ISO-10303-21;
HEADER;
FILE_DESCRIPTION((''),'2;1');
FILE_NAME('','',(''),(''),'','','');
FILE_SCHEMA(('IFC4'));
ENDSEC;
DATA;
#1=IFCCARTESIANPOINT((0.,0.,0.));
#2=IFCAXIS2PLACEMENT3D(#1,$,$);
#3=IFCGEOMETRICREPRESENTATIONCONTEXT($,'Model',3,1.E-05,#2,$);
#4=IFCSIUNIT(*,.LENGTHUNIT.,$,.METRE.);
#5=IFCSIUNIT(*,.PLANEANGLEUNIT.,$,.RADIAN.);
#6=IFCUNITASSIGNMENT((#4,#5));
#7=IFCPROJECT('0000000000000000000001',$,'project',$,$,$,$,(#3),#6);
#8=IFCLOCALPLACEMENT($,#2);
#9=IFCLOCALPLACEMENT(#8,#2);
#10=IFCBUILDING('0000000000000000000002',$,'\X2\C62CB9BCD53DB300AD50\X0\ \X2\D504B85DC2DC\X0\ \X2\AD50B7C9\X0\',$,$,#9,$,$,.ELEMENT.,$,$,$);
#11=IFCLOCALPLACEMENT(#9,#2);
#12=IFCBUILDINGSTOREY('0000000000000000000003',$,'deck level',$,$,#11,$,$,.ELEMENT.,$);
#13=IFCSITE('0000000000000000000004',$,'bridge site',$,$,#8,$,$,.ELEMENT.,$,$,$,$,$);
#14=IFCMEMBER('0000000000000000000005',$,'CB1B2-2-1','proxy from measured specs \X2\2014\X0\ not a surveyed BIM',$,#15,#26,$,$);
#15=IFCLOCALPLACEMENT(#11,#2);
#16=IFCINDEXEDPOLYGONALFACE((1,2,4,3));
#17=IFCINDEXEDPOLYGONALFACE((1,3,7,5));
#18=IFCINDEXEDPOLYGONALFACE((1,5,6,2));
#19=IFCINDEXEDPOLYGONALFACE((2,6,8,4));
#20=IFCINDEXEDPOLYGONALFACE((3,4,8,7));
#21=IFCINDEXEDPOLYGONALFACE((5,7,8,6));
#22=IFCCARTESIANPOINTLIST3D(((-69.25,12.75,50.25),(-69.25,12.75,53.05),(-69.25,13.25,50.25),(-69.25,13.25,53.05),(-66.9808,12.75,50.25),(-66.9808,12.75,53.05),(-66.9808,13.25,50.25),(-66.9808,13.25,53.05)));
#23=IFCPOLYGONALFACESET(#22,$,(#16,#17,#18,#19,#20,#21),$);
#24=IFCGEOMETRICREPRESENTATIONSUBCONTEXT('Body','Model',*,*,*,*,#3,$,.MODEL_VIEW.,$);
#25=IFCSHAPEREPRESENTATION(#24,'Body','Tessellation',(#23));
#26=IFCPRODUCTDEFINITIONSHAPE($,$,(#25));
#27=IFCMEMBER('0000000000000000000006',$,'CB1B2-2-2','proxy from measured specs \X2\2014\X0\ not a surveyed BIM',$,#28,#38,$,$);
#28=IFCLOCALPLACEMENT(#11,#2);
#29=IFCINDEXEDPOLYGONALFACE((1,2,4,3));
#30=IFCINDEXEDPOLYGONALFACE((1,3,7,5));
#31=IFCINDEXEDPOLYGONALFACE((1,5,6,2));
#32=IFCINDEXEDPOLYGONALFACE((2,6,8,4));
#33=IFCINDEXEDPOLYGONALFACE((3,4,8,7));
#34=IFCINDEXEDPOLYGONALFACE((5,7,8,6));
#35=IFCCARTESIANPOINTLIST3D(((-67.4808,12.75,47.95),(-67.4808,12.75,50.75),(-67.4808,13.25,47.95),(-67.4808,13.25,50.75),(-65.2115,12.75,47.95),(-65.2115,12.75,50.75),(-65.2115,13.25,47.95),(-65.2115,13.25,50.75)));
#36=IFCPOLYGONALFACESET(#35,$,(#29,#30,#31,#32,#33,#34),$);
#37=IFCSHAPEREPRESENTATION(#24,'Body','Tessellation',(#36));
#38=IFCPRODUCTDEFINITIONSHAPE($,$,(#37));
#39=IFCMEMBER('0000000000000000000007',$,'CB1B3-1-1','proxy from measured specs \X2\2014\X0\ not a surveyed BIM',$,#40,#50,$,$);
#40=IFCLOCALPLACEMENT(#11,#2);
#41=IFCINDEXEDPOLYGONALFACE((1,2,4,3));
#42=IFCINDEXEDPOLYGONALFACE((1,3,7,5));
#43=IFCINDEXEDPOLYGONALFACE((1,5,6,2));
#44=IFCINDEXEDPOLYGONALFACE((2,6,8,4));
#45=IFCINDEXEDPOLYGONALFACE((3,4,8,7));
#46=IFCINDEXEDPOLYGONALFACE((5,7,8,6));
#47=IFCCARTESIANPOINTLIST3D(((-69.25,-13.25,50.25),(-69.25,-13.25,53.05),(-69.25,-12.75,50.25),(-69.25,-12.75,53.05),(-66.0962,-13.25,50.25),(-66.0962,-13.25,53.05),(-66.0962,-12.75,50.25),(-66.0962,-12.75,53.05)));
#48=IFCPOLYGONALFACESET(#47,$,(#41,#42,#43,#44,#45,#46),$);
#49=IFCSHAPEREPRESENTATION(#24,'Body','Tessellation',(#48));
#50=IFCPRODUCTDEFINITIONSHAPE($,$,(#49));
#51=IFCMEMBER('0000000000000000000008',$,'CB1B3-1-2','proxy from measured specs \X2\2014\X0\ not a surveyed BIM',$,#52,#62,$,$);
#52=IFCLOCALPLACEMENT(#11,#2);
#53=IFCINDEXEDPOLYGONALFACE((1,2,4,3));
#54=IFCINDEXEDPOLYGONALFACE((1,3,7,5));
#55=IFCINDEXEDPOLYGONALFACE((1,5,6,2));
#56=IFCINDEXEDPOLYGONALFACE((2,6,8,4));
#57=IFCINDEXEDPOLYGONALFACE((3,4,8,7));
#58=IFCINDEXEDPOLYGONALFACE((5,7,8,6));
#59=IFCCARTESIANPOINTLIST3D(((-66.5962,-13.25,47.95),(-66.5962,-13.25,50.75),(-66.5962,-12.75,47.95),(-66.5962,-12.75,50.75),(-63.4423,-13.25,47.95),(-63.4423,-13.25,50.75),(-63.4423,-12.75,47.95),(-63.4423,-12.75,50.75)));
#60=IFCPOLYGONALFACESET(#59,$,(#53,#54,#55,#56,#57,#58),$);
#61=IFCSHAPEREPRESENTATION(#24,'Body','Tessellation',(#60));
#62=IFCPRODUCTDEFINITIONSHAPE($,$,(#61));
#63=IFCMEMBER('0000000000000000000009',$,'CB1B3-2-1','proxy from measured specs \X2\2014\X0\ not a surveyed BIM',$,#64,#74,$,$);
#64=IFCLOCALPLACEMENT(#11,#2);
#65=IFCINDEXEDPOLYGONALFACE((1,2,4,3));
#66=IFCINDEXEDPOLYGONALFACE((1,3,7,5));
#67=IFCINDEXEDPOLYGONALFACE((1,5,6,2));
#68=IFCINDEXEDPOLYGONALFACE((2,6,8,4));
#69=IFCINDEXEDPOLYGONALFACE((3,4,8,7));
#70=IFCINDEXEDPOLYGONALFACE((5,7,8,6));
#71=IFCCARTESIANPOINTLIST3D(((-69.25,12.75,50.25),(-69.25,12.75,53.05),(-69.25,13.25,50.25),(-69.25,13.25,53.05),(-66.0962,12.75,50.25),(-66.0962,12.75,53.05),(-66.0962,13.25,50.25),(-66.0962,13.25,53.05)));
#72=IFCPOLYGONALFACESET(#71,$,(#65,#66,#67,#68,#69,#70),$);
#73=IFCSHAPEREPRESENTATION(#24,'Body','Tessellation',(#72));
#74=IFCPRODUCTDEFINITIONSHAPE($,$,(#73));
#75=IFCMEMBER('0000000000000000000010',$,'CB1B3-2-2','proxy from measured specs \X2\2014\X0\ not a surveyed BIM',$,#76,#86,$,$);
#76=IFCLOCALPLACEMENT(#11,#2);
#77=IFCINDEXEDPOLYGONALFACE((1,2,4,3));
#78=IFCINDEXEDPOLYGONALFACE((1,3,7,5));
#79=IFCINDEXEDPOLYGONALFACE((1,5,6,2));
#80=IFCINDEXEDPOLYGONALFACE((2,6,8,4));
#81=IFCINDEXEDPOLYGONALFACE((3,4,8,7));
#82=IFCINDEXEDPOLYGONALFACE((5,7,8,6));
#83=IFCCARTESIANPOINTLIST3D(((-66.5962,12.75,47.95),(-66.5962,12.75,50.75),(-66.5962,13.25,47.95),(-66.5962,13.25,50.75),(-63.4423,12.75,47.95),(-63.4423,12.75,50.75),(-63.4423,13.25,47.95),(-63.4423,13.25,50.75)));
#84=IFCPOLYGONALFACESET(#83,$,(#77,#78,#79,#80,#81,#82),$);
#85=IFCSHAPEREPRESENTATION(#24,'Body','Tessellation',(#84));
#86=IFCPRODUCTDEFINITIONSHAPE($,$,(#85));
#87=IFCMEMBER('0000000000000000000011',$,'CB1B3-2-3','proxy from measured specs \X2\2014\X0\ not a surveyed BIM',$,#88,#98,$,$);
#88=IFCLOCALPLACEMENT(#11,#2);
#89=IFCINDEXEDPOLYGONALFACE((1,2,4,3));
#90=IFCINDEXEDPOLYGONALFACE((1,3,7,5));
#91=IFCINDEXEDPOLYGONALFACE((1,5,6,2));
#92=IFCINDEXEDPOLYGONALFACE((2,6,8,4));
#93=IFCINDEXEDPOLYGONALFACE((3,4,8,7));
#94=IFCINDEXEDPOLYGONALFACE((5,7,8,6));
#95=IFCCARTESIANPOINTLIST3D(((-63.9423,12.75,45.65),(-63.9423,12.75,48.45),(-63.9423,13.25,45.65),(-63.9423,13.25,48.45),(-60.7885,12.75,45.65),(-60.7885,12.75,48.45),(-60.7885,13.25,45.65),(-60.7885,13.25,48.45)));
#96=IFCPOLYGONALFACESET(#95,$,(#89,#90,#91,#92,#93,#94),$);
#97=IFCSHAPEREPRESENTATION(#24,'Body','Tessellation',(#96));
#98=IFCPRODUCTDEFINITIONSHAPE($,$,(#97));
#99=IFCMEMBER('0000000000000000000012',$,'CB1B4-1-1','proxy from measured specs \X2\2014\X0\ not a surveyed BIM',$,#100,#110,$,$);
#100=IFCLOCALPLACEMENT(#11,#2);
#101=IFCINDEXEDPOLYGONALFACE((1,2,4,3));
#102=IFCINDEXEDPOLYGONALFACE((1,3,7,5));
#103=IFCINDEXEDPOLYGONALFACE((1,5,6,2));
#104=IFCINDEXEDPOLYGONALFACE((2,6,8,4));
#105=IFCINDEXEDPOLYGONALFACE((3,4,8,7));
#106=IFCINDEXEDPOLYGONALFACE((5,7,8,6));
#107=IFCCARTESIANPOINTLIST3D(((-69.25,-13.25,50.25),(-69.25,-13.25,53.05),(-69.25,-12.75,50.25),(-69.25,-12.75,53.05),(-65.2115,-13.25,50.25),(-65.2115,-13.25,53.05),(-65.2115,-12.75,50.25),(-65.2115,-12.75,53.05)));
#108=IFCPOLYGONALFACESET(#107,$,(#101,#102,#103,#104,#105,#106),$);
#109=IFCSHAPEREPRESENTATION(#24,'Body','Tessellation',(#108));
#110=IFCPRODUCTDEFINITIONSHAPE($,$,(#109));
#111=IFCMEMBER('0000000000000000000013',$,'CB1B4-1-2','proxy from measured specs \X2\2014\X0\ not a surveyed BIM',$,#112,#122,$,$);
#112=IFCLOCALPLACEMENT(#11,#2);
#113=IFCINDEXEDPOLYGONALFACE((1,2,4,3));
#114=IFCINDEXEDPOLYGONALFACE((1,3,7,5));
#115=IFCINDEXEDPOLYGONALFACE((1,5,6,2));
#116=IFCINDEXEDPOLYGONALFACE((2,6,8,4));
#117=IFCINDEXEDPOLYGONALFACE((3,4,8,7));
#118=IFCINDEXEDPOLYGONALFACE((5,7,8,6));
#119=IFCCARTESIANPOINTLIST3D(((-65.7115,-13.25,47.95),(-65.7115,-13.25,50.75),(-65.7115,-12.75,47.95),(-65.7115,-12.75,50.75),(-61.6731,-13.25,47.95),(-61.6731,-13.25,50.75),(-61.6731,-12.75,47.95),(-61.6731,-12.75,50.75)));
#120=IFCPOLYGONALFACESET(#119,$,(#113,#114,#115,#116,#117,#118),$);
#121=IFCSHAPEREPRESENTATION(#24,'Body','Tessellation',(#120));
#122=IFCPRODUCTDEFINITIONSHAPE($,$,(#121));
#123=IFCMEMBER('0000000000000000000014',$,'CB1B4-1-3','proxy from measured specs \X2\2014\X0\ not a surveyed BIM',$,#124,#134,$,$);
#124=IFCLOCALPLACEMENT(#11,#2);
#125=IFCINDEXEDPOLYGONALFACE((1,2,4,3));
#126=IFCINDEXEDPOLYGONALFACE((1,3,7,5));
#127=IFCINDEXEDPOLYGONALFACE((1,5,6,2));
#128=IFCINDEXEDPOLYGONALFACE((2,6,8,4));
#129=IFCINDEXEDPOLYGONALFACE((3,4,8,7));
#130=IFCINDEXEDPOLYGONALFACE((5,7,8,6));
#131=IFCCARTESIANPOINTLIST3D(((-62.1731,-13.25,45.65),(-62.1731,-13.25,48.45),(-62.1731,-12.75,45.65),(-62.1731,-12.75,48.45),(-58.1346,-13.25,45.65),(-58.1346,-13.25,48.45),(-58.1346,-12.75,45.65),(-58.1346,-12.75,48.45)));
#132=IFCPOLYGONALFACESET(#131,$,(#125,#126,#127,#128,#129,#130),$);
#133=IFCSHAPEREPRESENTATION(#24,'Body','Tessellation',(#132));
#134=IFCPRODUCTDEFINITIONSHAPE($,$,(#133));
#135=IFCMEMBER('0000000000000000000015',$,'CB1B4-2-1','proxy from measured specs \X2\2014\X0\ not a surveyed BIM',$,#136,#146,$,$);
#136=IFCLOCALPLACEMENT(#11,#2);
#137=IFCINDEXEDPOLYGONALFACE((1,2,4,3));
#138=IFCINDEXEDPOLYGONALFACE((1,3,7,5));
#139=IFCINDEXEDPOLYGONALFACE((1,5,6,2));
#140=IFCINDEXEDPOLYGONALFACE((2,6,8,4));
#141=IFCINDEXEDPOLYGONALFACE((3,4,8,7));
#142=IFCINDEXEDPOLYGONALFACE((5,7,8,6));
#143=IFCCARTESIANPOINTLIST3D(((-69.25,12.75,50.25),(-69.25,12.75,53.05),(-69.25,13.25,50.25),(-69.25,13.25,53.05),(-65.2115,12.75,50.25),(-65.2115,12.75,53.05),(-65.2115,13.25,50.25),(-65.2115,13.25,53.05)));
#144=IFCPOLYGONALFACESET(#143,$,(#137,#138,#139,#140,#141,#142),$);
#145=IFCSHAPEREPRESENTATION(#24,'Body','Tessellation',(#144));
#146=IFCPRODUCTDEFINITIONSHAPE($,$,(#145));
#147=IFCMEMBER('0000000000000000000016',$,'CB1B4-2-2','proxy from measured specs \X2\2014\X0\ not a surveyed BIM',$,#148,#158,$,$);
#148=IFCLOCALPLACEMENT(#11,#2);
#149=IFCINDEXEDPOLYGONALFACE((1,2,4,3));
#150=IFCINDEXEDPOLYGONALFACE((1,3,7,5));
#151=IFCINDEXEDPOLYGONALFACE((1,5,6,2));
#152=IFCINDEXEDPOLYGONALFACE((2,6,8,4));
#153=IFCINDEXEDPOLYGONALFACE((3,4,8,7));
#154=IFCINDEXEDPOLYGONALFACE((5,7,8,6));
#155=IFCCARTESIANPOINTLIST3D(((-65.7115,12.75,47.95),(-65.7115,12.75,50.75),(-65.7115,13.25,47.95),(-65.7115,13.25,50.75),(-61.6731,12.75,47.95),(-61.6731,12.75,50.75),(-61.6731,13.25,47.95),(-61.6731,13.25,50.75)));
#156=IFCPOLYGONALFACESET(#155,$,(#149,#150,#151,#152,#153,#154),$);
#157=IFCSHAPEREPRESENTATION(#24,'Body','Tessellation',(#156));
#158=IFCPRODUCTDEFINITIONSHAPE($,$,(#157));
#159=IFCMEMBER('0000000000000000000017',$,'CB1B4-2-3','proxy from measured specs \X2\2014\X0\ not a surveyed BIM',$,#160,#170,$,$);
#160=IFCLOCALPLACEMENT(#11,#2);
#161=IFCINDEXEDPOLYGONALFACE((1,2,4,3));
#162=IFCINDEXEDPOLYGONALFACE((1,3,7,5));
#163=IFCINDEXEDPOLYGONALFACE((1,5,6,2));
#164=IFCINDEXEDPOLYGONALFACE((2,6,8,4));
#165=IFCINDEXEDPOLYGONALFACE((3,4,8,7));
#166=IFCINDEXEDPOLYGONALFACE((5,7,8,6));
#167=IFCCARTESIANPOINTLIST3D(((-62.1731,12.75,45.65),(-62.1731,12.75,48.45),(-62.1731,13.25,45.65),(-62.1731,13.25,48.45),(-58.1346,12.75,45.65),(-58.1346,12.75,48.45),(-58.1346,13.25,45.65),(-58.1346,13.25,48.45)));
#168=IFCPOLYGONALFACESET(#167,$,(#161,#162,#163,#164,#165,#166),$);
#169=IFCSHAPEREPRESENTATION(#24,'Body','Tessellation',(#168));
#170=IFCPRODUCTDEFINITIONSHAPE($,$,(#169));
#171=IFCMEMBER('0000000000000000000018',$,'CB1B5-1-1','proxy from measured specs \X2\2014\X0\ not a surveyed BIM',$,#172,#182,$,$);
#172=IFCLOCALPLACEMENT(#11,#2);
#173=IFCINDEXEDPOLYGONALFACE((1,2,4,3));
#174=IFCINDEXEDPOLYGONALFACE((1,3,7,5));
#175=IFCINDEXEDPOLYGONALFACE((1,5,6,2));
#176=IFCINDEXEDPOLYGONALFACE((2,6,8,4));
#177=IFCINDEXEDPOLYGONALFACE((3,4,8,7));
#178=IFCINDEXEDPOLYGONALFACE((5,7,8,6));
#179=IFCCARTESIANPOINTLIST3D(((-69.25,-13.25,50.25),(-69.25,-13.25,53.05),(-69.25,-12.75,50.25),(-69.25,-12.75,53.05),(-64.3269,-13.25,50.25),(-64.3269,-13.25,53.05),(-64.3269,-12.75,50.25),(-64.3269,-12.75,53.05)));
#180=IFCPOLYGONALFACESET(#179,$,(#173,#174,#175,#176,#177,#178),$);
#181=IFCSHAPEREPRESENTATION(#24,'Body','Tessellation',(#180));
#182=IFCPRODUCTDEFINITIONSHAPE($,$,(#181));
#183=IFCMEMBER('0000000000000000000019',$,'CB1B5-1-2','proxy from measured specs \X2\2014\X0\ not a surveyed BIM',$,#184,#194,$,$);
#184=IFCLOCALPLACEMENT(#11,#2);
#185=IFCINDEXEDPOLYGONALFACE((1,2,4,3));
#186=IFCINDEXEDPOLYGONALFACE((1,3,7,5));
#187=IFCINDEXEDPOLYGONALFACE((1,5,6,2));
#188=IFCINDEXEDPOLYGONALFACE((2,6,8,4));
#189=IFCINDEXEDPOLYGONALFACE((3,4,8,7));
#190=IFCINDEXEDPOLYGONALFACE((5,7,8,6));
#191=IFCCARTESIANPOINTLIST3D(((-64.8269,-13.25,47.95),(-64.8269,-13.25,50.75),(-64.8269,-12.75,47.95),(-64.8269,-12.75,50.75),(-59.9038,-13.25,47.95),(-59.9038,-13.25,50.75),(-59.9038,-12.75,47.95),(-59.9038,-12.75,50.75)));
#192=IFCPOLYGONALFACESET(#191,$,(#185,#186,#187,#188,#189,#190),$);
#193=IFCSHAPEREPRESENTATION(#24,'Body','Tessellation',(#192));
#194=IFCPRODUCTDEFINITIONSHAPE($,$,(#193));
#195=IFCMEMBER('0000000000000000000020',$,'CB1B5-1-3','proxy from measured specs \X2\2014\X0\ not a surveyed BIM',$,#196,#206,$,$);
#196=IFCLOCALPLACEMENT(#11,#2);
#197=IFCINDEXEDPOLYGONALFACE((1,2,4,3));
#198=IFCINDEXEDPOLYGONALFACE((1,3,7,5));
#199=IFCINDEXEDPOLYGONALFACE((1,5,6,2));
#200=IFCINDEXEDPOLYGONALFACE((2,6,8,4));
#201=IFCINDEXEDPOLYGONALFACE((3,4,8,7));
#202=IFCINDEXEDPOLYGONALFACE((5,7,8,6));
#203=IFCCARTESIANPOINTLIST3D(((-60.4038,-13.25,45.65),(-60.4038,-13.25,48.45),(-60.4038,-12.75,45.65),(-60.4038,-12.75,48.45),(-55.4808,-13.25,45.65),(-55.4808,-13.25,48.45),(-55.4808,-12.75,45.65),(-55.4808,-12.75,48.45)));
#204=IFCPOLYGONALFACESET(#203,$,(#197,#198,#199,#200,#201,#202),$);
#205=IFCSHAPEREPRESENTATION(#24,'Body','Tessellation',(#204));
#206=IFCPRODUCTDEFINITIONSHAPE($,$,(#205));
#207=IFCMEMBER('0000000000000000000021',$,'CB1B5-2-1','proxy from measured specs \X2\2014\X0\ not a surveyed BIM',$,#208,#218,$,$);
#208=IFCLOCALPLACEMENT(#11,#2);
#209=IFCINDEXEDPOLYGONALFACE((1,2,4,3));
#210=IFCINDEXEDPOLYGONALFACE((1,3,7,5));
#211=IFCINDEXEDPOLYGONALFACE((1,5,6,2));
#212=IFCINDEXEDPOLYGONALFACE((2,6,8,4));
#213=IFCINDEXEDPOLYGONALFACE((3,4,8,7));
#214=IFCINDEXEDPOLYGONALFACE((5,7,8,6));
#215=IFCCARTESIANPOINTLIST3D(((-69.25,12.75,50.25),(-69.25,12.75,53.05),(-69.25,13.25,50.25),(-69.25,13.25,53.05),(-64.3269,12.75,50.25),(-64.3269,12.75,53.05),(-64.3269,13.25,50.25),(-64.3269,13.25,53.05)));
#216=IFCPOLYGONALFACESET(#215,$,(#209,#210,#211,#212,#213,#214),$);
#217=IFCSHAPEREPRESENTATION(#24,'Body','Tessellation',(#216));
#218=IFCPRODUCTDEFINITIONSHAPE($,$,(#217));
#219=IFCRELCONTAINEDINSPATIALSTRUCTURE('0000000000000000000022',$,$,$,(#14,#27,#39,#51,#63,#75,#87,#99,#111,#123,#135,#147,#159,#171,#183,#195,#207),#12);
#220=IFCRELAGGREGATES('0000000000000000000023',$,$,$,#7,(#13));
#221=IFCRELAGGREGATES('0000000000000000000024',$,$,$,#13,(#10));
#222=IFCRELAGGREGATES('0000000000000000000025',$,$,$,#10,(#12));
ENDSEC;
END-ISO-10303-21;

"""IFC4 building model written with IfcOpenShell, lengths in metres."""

from ifc_helpers import new_model, si_unit, frame, origin, origin_2d, place, context, subcontext, project, spatial, rectangle, extrude, element, save


model = new_model("IFC4")

# Units and contexts
model_context = context("Model", 3, precision=1e-05, world=origin())
body_context = subcontext(model_context, "Body", "Model", "MODEL_VIEW")
ifc_project = project(units=[si_unit("LENGTHUNIT", "METRE"), si_unit("PLANEANGLEUNIT", "RADIAN")], contexts=[model_context])

# Site, building, storey
site_placement = place(None, origin())
site = spatial("IfcSite", under=ifc_project, at=site_placement, Name="bridge site", CompositionType="ELEMENT")
building_placement = place(site_placement, origin())
building = spatial("IfcBuilding", under=site, at=building_placement, Name="올림픽대교 프록시 교량", CompositionType="ELEMENT")
storey_placement = place(building_placement, origin())
storey = spatial("IfcBuildingStorey", under=building, at=storey_placement, Name="deck level", CompositionType="ELEMENT")

# Members
member_1_placement = place(storey_placement, frame((-68.1154, 13.0, 50.25)))
element("IfcMember", 1, at=member_1_placement, inside=storey, Name="CB1B2-2-1", Description="proxy from measured specs — not a surveyed BIM", context=body_context, shape_type="SweptSolid", body=[
    extrude(rectangle(XDim=2.2692, YDim=0.5, at=origin_2d()), origin(), (0.0, 0.0, 1.0), 2.8),
])
member_2_placement = place(storey_placement, frame((-66.3462, 13.0, 47.95)))
element("IfcMember", 2, at=member_2_placement, inside=storey, Name="CB1B2-2-2", Description="proxy from measured specs — not a surveyed BIM", context=body_context, shape_type="SweptSolid", body=[
    extrude(rectangle(XDim=2.2692, YDim=0.5, at=origin_2d()), origin(), (0.0, 0.0, 1.0), 2.8),
])
member_3_placement = place(storey_placement, frame((-67.6731, -13.0, 50.25)))
element("IfcMember", 3, at=member_3_placement, inside=storey, Name="CB1B3-1-1", Description="proxy from measured specs — not a surveyed BIM", context=body_context, shape_type="SweptSolid", body=[
    extrude(rectangle(XDim=3.1538, YDim=0.5, at=origin_2d()), origin(), (0.0, 0.0, 1.0), 2.8),
])
member_4_placement = place(storey_placement, frame((-65.0192, -13.0, 47.95)))
element("IfcMember", 4, at=member_4_placement, inside=storey, Name="CB1B3-1-2", Description="proxy from measured specs — not a surveyed BIM", context=body_context, shape_type="SweptSolid", body=[
    extrude(rectangle(XDim=3.1538, YDim=0.5, at=origin_2d()), origin(), (0.0, 0.0, 1.0), 2.8),
])
member_5_placement = place(storey_placement, frame((-67.6731, 13.0, 50.25)))
element("IfcMember", 5, at=member_5_placement, inside=storey, Name="CB1B3-2-1", Description="proxy from measured specs — not a surveyed BIM", context=body_context, shape_type="SweptSolid", body=[
    extrude(rectangle(XDim=3.1538, YDim=0.5, at=origin_2d()), origin(), (0.0, 0.0, 1.0), 2.8),
])
member_6_placement = place(storey_placement, frame((-65.0192, 13.0, 47.95)))
element("IfcMember", 6, at=member_6_placement, inside=storey, Name="CB1B3-2-2", Description="proxy from measured specs — not a surveyed BIM", context=body_context, shape_type="SweptSolid", body=[
    extrude(rectangle(XDim=3.1538, YDim=0.5, at=origin_2d()), origin(), (0.0, 0.0, 1.0), 2.8),
])
member_7_placement = place(storey_placement, frame((-62.3654, 13.0, 45.65)))
element("IfcMember", 7, at=member_7_placement, inside=storey, Name="CB1B3-2-3", Description="proxy from measured specs — not a surveyed BIM", context=body_context, shape_type="SweptSolid", body=[
    extrude(rectangle(XDim=3.1538, YDim=0.5, at=origin_2d()), origin(), (0.0, 0.0, 1.0), 2.8),
])
member_8_placement = place(storey_placement, frame((-67.2308, -13.0, 50.25)))
element("IfcMember", 8, at=member_8_placement, inside=storey, Name="CB1B4-1-1", Description="proxy from measured specs — not a surveyed BIM", context=body_context, shape_type="SweptSolid", body=[
    extrude(rectangle(XDim=4.0385, YDim=0.5, at=origin_2d()), origin(), (0.0, 0.0, 1.0), 2.8),
])
member_9_placement = place(storey_placement, frame((-63.6923, -13.0, 47.95)))
element("IfcMember", 9, at=member_9_placement, inside=storey, Name="CB1B4-1-2", Description="proxy from measured specs — not a surveyed BIM", context=body_context, shape_type="SweptSolid", body=[
    extrude(rectangle(XDim=4.0385, YDim=0.5, at=origin_2d()), origin(), (0.0, 0.0, 1.0), 2.8),
])
for number, where, name in (
    (10, (-60.1538, -13.0, 45.65), "CB1B4-1-3"),
    (11, (-67.2308, 13.0, 50.25), "CB1B4-2-1"),
):
    element("IfcMember", number, at=place(storey_placement, frame(where)), inside=storey, Name=name, Description="proxy from measured specs — not a surveyed BIM", context=body_context, shape_type="SweptSolid", body=[
        extrude(rectangle(XDim=4.0385, YDim=0.5, at=origin_2d()), origin(), (0.0, 0.0, 1.0), 2.8),
    ])
member_10_placement = place(storey_placement, frame((-63.6923, 13.0, 47.95)))
element("IfcMember", 12, at=member_10_placement, inside=storey, Name="CB1B4-2-2", Description="proxy from measured specs — not a surveyed BIM", context=body_context, shape_type="SweptSolid", body=[
    extrude(rectangle(XDim=4.0385, YDim=0.5, at=origin_2d()), origin(), (0.0, 0.0, 1.0), 2.8),
])
member_11_placement = place(storey_placement, frame((-60.1538, 13.0, 45.65)))
element("IfcMember", 13, at=member_11_placement, inside=storey, Name="CB1B4-2-3", Description="proxy from measured specs — not a surveyed BIM", context=body_context, shape_type="SweptSolid", body=[
    extrude(rectangle(XDim=4.0385, YDim=0.5, at=origin_2d()), origin(), (0.0, 0.0, 1.0), 2.8),
])
member_12_placement = place(storey_placement, frame((-66.7885, -13.0, 50.25)))
element("IfcMember", 14, at=member_12_placement, inside=storey, Name="CB1B5-1-1", Description="proxy from measured specs — not a surveyed BIM", context=body_context, shape_type="SweptSolid", body=[
    extrude(rectangle(XDim=4.9231, YDim=0.5, at=origin_2d()), origin(), (0.0, 0.0, 1.0), 2.8),
])
member_13_placement = place(storey_placement, frame((-62.3654, -13.0, 47.95)))
element("IfcMember", 15, at=member_13_placement, inside=storey, Name="CB1B5-1-2", Description="proxy from measured specs — not a surveyed BIM", context=body_context, shape_type="SweptSolid", body=[
    extrude(rectangle(XDim=4.9231, YDim=0.5, at=origin_2d()), origin(), (0.0, 0.0, 1.0), 2.8),
])
for number, where, name in (
    (16, (-57.9423, -13.0, 45.65), "CB1B5-1-3"),
    (17, (-66.7885, 13.0, 50.25), "CB1B5-2-1"),
):
    element("IfcMember", number, at=place(storey_placement, frame(where)), inside=storey, Name=name, Description="proxy from measured specs — not a surveyed BIM", context=body_context, shape_type="SweptSolid", body=[
        extrude(rectangle(XDim=4.9231, YDim=0.5, at=origin_2d()), origin(), (0.0, 0.0, 1.0), 2.8),
    ])

save(model, "model.ifc")
